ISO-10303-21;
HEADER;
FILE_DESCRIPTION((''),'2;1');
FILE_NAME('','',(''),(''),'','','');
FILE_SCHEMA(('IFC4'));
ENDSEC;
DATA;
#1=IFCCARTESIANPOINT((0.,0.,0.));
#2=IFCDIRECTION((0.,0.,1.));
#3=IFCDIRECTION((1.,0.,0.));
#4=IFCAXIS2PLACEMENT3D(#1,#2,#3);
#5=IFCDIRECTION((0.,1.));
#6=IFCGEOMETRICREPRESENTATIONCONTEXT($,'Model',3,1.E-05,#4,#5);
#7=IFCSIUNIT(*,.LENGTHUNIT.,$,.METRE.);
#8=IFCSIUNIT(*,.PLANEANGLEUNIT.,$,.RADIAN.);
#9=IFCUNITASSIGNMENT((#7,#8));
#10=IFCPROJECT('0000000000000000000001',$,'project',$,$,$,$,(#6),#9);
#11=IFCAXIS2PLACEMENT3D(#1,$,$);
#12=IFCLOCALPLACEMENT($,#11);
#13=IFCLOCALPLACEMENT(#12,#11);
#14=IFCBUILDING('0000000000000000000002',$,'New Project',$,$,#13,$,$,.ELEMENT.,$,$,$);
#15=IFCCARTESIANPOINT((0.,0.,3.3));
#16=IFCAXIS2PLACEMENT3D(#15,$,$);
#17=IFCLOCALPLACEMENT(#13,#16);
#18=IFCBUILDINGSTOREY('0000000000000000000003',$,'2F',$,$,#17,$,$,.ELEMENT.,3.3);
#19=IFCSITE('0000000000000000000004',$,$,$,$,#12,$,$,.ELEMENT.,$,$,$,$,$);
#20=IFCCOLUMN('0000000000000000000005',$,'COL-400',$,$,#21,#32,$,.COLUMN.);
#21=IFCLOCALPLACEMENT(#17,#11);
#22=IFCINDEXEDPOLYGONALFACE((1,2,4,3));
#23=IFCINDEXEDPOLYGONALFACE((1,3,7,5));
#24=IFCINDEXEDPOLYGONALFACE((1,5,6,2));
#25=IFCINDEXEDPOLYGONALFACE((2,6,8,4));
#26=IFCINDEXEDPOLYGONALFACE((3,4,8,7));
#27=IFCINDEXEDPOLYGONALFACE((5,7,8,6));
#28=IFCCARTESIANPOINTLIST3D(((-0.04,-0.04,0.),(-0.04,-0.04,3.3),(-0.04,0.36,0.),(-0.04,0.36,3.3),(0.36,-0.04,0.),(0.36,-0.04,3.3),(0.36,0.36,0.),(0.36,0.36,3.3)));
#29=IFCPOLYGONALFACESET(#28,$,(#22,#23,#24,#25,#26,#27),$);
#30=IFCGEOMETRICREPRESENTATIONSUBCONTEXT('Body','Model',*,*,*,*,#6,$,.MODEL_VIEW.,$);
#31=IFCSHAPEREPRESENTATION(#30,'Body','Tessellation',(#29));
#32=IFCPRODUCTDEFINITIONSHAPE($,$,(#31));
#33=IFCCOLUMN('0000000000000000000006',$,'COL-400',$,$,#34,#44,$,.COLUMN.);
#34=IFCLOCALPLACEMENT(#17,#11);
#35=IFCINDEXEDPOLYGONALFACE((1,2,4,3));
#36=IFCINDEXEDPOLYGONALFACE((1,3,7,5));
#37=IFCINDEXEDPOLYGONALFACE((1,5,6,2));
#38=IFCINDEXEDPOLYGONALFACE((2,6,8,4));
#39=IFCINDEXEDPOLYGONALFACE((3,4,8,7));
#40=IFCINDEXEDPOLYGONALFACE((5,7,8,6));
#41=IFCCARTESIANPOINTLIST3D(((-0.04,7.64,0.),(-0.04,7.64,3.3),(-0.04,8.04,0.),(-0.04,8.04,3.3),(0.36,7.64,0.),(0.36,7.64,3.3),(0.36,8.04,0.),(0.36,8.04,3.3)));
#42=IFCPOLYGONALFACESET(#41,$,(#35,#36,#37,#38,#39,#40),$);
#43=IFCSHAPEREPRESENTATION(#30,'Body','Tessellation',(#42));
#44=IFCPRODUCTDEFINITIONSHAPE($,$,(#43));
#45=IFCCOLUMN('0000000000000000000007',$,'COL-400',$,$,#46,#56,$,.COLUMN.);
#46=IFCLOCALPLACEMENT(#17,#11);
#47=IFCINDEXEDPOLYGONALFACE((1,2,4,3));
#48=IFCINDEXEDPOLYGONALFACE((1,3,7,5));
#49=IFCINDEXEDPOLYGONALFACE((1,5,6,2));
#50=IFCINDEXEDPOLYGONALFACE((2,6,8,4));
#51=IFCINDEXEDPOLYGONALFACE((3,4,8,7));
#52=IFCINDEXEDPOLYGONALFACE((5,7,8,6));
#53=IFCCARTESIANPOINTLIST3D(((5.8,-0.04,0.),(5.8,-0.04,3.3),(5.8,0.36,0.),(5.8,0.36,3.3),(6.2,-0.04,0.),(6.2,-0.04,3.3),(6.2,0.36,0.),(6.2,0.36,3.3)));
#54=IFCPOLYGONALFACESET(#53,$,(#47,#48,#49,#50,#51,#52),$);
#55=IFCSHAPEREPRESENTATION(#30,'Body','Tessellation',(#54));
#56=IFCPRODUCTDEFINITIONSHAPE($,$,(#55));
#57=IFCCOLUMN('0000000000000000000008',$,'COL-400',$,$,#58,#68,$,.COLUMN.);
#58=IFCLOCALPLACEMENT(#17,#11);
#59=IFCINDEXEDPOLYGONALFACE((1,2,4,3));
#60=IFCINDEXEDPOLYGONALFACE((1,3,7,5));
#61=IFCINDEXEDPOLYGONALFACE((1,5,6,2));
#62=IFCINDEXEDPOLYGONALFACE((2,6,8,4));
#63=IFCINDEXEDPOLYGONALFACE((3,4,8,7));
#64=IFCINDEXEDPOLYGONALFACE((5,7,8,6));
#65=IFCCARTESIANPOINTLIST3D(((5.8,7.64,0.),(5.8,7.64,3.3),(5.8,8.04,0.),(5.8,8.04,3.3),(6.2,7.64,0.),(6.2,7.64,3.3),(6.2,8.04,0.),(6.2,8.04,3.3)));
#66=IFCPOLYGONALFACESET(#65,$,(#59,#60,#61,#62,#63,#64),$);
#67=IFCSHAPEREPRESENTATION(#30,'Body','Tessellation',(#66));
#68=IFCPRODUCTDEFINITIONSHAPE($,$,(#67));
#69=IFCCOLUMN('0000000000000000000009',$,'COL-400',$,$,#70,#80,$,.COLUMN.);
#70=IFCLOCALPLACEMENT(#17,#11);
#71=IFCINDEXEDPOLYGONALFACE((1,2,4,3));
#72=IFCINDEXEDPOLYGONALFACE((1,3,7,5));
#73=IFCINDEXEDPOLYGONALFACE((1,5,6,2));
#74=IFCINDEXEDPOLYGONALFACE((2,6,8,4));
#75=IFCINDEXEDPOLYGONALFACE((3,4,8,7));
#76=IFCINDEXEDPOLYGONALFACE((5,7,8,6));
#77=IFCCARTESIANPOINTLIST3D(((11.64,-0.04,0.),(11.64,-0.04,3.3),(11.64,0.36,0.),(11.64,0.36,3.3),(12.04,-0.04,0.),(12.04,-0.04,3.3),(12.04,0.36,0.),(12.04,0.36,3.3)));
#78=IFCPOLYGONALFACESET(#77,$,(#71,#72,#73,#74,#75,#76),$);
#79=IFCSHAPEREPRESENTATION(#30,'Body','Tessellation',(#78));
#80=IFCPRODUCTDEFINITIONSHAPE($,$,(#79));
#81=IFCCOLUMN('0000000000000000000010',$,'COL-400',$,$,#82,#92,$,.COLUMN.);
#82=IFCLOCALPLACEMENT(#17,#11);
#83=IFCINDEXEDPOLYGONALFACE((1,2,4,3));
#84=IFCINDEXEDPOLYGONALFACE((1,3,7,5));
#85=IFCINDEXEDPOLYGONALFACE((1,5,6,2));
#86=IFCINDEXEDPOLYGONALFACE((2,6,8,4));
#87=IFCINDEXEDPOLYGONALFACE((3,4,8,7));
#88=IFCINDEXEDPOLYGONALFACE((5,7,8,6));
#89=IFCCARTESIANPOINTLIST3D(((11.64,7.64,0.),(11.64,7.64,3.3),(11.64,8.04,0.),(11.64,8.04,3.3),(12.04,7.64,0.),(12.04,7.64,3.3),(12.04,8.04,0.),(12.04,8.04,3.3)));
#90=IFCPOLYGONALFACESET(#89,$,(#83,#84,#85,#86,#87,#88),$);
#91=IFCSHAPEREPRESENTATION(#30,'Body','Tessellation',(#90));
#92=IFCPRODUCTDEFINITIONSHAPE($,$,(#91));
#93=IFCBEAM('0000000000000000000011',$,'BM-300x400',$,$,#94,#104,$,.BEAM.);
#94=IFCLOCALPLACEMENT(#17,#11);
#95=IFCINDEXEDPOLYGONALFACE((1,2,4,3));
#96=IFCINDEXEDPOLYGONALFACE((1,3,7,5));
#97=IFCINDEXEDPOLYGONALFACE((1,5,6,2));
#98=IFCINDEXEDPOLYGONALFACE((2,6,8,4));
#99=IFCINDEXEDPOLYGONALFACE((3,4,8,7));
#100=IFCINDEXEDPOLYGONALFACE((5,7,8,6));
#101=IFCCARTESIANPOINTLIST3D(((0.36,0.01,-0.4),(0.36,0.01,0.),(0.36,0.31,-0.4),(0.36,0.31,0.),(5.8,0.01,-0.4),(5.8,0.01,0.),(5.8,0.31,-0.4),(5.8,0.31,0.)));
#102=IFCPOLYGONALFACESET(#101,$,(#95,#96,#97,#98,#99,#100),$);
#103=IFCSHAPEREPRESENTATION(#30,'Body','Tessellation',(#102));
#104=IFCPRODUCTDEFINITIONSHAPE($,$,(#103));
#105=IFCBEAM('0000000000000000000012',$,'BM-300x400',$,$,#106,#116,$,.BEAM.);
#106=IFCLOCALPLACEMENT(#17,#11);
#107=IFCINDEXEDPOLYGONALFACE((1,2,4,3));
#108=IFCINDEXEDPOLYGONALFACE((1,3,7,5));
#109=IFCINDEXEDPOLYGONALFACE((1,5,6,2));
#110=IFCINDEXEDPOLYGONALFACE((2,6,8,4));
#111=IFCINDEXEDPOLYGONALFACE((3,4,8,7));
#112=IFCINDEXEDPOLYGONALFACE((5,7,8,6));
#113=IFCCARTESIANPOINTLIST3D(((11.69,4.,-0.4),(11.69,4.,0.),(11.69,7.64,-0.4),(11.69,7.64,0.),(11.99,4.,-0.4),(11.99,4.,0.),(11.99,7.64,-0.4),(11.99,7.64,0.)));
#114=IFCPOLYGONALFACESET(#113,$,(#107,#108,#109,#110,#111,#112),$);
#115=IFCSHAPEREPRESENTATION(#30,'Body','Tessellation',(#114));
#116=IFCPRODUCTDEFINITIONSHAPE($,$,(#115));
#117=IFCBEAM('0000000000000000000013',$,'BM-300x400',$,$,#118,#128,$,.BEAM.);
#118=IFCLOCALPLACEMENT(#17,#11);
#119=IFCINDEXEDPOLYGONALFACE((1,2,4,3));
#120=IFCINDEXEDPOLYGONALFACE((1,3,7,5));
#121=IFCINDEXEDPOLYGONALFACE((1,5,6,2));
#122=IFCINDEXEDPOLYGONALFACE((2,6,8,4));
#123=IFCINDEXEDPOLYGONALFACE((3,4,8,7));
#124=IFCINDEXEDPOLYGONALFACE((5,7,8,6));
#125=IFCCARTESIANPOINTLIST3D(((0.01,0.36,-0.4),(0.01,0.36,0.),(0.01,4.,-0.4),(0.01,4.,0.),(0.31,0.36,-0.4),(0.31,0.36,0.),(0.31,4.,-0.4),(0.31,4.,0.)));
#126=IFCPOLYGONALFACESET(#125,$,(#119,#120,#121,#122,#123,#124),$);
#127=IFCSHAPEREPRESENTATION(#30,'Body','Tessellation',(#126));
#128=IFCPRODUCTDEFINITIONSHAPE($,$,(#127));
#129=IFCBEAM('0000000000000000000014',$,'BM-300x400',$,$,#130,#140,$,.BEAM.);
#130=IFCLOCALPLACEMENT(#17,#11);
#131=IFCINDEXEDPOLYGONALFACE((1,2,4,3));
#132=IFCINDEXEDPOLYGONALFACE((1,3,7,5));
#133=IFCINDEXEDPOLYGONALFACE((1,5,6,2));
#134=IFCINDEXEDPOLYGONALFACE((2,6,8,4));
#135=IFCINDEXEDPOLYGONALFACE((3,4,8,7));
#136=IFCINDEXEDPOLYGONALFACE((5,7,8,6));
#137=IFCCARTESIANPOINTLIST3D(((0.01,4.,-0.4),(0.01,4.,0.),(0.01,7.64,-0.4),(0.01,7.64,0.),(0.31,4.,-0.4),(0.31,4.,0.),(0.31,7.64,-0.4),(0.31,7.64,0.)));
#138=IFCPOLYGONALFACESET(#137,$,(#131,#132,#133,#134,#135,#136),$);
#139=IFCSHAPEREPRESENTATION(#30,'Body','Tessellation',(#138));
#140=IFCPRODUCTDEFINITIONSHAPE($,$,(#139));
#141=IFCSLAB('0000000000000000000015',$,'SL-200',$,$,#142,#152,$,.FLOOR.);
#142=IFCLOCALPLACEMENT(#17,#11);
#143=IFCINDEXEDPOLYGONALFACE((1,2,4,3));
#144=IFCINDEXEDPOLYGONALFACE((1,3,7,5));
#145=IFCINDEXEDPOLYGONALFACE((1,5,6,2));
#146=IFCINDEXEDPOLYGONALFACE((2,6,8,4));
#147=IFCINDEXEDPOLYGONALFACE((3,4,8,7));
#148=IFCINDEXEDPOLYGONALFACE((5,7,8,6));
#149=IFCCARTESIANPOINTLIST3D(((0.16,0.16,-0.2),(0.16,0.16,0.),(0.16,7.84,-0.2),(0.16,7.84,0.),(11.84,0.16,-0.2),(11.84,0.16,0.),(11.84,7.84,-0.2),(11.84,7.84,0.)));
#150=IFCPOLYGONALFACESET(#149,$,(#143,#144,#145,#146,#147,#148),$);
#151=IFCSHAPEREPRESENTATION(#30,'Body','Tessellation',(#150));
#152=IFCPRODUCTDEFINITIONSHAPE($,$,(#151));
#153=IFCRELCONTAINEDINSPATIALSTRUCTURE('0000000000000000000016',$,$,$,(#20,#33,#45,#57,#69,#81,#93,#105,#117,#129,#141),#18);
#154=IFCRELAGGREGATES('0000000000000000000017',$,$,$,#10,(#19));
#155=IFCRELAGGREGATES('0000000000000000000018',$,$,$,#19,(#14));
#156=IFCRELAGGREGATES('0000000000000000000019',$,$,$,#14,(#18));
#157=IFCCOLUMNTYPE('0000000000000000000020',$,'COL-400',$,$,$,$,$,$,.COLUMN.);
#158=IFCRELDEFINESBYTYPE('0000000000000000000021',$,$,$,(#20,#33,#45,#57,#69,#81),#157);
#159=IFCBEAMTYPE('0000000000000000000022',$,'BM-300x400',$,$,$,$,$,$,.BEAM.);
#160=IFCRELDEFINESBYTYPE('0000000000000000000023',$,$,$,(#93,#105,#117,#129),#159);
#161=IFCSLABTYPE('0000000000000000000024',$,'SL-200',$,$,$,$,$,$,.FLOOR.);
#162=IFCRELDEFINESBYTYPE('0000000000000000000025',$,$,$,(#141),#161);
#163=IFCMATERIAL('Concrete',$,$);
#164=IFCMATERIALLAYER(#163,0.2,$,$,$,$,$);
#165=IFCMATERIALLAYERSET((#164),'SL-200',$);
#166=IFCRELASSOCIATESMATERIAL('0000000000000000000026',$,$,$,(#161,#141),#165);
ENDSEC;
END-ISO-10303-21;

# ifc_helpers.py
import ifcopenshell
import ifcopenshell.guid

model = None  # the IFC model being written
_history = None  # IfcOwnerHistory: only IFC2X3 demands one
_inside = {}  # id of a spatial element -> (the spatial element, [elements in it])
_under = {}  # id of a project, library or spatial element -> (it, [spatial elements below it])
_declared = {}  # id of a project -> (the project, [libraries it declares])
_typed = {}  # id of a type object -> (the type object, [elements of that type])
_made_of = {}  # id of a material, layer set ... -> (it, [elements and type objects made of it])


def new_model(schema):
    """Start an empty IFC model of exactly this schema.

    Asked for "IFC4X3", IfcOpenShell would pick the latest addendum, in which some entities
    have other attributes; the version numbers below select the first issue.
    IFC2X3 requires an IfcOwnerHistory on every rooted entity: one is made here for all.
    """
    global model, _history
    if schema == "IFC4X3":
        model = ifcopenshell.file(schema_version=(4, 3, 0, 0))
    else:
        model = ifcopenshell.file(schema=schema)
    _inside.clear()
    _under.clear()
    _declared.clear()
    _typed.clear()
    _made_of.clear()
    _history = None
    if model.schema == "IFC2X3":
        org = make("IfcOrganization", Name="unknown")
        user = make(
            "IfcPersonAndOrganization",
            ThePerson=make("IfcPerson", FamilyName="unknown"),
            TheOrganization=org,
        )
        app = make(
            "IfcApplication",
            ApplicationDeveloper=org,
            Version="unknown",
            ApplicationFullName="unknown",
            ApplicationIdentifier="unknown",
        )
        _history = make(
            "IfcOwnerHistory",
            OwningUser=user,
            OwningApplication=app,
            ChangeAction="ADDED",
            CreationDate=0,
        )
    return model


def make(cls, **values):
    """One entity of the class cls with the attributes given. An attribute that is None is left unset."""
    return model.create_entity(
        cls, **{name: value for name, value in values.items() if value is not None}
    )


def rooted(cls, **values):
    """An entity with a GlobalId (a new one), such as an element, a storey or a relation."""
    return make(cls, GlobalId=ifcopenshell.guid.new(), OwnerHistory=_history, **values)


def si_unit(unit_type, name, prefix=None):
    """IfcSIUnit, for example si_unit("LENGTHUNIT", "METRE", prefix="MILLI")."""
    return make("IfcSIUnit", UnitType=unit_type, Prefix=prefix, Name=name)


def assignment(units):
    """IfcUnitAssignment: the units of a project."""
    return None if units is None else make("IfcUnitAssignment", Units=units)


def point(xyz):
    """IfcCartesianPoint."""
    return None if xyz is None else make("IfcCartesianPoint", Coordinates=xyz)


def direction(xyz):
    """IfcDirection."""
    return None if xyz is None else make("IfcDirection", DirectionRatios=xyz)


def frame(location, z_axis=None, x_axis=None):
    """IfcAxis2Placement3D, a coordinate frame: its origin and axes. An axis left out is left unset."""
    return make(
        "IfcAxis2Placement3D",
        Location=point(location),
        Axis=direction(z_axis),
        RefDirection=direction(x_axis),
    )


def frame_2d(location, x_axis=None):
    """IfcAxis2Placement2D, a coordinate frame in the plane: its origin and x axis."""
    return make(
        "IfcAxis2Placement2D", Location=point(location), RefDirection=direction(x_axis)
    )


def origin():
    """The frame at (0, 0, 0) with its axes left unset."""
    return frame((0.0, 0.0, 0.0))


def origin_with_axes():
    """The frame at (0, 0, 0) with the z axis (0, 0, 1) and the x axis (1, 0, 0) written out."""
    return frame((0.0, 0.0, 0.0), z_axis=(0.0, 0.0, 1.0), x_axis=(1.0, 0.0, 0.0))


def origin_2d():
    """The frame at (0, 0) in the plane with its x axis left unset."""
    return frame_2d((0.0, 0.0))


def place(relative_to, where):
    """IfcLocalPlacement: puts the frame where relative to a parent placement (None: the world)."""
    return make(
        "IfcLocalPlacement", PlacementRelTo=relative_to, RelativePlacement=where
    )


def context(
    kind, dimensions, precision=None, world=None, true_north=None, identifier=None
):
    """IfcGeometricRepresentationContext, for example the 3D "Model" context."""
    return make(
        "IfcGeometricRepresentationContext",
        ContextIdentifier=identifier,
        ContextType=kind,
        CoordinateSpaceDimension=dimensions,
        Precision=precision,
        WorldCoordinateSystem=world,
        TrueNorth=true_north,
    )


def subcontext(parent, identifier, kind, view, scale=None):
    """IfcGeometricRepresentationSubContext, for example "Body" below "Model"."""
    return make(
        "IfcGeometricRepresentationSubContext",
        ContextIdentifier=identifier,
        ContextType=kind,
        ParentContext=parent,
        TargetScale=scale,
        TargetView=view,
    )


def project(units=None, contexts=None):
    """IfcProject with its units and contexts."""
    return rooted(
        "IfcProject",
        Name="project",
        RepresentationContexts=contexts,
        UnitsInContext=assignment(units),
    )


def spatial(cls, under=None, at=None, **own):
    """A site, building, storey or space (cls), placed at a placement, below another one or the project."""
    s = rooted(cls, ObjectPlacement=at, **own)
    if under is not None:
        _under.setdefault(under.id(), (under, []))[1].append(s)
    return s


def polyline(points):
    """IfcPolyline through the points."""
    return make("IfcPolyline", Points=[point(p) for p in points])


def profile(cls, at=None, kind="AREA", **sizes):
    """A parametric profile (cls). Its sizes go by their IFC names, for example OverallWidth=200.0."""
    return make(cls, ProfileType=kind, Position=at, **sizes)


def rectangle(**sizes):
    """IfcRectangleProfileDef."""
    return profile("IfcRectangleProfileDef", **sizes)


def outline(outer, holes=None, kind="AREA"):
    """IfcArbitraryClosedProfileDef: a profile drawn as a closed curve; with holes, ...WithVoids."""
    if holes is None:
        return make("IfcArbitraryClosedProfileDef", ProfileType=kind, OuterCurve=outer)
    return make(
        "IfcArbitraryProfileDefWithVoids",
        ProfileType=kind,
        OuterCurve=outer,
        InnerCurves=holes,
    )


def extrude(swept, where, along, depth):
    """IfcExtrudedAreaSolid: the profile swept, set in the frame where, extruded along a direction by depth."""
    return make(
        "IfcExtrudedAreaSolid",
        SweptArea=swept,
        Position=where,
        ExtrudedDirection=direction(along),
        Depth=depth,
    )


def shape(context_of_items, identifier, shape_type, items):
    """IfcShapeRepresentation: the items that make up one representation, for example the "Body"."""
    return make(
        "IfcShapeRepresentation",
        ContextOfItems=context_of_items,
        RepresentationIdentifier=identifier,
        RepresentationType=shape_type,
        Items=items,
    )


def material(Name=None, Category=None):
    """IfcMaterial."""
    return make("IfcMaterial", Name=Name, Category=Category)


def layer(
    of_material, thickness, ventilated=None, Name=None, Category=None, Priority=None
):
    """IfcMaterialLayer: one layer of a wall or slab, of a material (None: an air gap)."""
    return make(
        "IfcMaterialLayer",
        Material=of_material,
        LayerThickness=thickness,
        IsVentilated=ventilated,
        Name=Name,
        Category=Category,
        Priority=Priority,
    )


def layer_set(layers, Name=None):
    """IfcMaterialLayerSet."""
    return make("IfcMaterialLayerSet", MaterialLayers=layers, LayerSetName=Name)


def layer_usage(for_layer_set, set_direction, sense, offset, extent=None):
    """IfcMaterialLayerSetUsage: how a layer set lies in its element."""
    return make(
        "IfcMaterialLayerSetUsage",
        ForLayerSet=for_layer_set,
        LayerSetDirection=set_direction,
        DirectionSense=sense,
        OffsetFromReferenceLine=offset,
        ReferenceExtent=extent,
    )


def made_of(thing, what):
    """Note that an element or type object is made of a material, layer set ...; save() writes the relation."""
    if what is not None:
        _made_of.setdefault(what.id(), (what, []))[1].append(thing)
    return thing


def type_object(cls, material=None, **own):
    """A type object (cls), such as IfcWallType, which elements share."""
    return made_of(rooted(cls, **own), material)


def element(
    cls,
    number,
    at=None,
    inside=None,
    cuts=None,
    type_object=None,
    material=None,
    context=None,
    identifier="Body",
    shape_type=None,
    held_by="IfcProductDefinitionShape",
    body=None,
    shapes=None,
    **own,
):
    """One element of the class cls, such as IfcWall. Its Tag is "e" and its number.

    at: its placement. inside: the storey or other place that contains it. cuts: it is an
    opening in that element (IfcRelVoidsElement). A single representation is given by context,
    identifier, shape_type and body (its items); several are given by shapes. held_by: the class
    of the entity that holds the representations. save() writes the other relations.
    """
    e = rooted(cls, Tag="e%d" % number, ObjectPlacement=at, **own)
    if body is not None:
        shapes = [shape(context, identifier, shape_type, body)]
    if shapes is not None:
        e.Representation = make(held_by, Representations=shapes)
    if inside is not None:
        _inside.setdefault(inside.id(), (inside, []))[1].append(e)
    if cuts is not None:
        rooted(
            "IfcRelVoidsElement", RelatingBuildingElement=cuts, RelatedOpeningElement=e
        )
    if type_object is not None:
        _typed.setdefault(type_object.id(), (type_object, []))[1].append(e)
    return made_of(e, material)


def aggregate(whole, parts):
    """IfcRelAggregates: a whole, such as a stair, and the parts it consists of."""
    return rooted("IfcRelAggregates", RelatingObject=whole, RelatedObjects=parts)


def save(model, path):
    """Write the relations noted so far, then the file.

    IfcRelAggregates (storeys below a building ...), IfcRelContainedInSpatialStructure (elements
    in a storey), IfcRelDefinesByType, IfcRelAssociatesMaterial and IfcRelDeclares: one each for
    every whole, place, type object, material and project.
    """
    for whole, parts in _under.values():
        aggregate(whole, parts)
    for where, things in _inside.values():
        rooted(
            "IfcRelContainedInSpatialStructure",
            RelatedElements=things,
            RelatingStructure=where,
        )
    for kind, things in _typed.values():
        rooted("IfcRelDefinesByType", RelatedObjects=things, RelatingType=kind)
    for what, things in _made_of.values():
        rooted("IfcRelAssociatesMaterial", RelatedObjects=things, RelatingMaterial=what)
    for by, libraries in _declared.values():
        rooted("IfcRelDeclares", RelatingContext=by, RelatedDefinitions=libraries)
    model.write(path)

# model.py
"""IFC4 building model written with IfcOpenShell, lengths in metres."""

from ifc_helpers import new_model, si_unit, direction, frame, frame_2d, origin, origin_with_axes, origin_2d, place, context, subcontext, project, spatial, polyline, rectangle, outline, extrude, material, layer, layer_set, layer_usage, type_object, element, save


model = new_model("IFC4")

# Units and contexts
model_context = context("Model", 3, precision=1e-05, world=origin_with_axes(), true_north=direction((0.0, 1.0)))
body_context = subcontext(model_context, "Body", "Model", "MODEL_VIEW")
ifc_project = project(units=[si_unit("LENGTHUNIT", "METRE"), si_unit("PLANEANGLEUNIT", "RADIAN")], contexts=[model_context])

# Site, building, storey
site_placement = place(None, origin())
site = spatial("IfcSite", under=ifc_project, at=site_placement, CompositionType="ELEMENT")
building_placement = place(site_placement, origin())
building = spatial("IfcBuilding", under=site, at=building_placement, Name="New Project", CompositionType="ELEMENT")
storey_placement = place(building_placement, frame((0.0, 0.0, 3.3)))
storey = spatial("IfcBuildingStorey", under=building, at=storey_placement, Name="2F", CompositionType="ELEMENT", Elevation=3.3)

# Columns
column_type = type_object("IfcColumnType", Name="COL-400", PredefinedType="COLUMN")
column_1_placement = place(storey_placement, origin())
element("IfcColumn", 1, at=column_1_placement, inside=storey, type_object=column_type, Name="COL-400", PredefinedType="COLUMN", context=body_context, shape_type="SweptSolid", body=[
    extrude(rectangle(XDim=0.4, YDim=0.4, at=origin_2d()), frame((0.16, 0.16, 0.0)), (0.0, 0.0, 1.0), 3.3),
])
column_2_placement = place(storey_placement, origin())
element("IfcColumn", 2, at=column_2_placement, inside=storey, type_object=column_type, Name="COL-400", PredefinedType="COLUMN", context=body_context, shape_type="SweptSolid", body=[
    extrude(rectangle(XDim=0.4, YDim=0.4, at=origin_2d()), frame((0.16, 7.84, 0.0)), (0.0, 0.0, 1.0), 3.3),
])
column_3_placement = place(storey_placement, origin())
element("IfcColumn", 3, at=column_3_placement, inside=storey, type_object=column_type, Name="COL-400", PredefinedType="COLUMN", context=body_context, shape_type="SweptSolid", body=[
    extrude(rectangle(XDim=0.4, YDim=0.4, at=origin_2d()), frame((6.0, 0.16, 0.0)), (0.0, 0.0, 1.0), 3.3),
])
column_4_placement = place(storey_placement, origin())
element("IfcColumn", 4, at=column_4_placement, inside=storey, type_object=column_type, Name="COL-400", PredefinedType="COLUMN", context=body_context, shape_type="SweptSolid", body=[
    extrude(rectangle(XDim=0.4, YDim=0.4, at=origin_2d()), frame((6.0, 7.84, 0.0)), (0.0, 0.0, 1.0), 3.3),
])
column_5_placement = place(storey_placement, origin())
element("IfcColumn", 5, at=column_5_placement, inside=storey, type_object=column_type, Name="COL-400", PredefinedType="COLUMN", context=body_context, shape_type="SweptSolid", body=[
    extrude(rectangle(XDim=0.4, YDim=0.4, at=origin_2d()), frame((11.84, 0.16, 0.0)), (0.0, 0.0, 1.0), 3.3),
])
column_6_placement = place(storey_placement, origin())
element("IfcColumn", 6, at=column_6_placement, inside=storey, type_object=column_type, Name="COL-400", PredefinedType="COLUMN", context=body_context, shape_type="SweptSolid", body=[
    extrude(rectangle(XDim=0.4, YDim=0.4, at=origin_2d()), frame((11.84, 7.84, 0.0)), (0.0, 0.0, 1.0), 3.3),
])

# Beams
beam_type = type_object("IfcBeamType", Name="BM-300x400", PredefinedType="BEAM")
beam_1_placement = place(storey_placement, origin())
element("IfcBeam", 7, at=beam_1_placement, inside=storey, type_object=beam_type, Name="BM-300x400", PredefinedType="BEAM", context=body_context, shape_type="SweptSolid", body=[
    extrude(rectangle(XDim=5.44, YDim=0.3, at=frame_2d((2.92, 0.0))), frame((0.16, 0.16, -0.4), z_axis=(0.0, 0.0, 1.0), x_axis=(1.0, 0.0, 0.0)), (0.0, 0.0, 1.0), 0.4),
])
beam_2_placement = place(storey_placement, origin())
element("IfcBeam", 8, at=beam_2_placement, inside=storey, type_object=beam_type, Name="BM-300x400", PredefinedType="BEAM", context=body_context, shape_type="SweptSolid", body=[
    extrude(rectangle(XDim=3.64, YDim=0.3, at=frame_2d((1.82, 0.0))), frame((11.84, 4.0, -0.4), z_axis=(0.0, 0.0, 1.0), x_axis=(0.0, 1.0, 0.0)), (0.0, 0.0, 1.0), 0.4),
])
beam_3_placement = place(storey_placement, origin())
element("IfcBeam", 9, at=beam_3_placement, inside=storey, type_object=beam_type, Name="BM-300x400", PredefinedType="BEAM", context=body_context, shape_type="SweptSolid", body=[
    extrude(rectangle(XDim=3.64, YDim=0.3, at=frame_2d((2.02, 0.0))), frame((0.16, 0.16, -0.4), z_axis=(0.0, 0.0, 1.0), x_axis=(0.0, 1.0, 0.0)), (0.0, 0.0, 1.0), 0.4),
])
beam_4_placement = place(storey_placement, origin())
element("IfcBeam", 10, at=beam_4_placement, inside=storey, type_object=beam_type, Name="BM-300x400", PredefinedType="BEAM", context=body_context, shape_type="SweptSolid", body=[
    extrude(rectangle(XDim=3.64, YDim=0.3, at=frame_2d((1.82, 0.0))), frame((0.16, 4.0, -0.4), z_axis=(0.0, 0.0, 1.0), x_axis=(0.0, 1.0, 0.0)), (0.0, 0.0, 1.0), 0.4),
])

# Slab
ifc_material_1 = material(Name="Concrete")
ifc_layer_1 = layer(ifc_material_1, 0.2)
ifc_layer_set_1 = layer_set([ifc_layer_1], Name="SL-200")
ifc_layer_usage_1 = layer_usage(ifc_layer_set_1, "AXIS3", "NEGATIVE", 0.2)
slab_type = type_object("IfcSlabType", Name="SL-200", PredefinedType="FLOOR", material=ifc_layer_set_1)
slab_placement = place(storey_placement, frame((0.0, 0.0, -0.2)))
element("IfcSlab", 11, at=slab_placement, inside=storey, type_object=slab_type, material=ifc_layer_usage_1, Name="SL-200", PredefinedType="FLOOR", context=body_context, shape_type="SweptSolid", body=[
    extrude(outline(polyline([(0.16, 0.16), (11.84, 0.16), (11.84, 7.84), (0.16, 7.84), (0.16, 0.16)])), origin(), (0.0, 0.0, 1.0), 0.2),
])

save(model, "model.ifc")
